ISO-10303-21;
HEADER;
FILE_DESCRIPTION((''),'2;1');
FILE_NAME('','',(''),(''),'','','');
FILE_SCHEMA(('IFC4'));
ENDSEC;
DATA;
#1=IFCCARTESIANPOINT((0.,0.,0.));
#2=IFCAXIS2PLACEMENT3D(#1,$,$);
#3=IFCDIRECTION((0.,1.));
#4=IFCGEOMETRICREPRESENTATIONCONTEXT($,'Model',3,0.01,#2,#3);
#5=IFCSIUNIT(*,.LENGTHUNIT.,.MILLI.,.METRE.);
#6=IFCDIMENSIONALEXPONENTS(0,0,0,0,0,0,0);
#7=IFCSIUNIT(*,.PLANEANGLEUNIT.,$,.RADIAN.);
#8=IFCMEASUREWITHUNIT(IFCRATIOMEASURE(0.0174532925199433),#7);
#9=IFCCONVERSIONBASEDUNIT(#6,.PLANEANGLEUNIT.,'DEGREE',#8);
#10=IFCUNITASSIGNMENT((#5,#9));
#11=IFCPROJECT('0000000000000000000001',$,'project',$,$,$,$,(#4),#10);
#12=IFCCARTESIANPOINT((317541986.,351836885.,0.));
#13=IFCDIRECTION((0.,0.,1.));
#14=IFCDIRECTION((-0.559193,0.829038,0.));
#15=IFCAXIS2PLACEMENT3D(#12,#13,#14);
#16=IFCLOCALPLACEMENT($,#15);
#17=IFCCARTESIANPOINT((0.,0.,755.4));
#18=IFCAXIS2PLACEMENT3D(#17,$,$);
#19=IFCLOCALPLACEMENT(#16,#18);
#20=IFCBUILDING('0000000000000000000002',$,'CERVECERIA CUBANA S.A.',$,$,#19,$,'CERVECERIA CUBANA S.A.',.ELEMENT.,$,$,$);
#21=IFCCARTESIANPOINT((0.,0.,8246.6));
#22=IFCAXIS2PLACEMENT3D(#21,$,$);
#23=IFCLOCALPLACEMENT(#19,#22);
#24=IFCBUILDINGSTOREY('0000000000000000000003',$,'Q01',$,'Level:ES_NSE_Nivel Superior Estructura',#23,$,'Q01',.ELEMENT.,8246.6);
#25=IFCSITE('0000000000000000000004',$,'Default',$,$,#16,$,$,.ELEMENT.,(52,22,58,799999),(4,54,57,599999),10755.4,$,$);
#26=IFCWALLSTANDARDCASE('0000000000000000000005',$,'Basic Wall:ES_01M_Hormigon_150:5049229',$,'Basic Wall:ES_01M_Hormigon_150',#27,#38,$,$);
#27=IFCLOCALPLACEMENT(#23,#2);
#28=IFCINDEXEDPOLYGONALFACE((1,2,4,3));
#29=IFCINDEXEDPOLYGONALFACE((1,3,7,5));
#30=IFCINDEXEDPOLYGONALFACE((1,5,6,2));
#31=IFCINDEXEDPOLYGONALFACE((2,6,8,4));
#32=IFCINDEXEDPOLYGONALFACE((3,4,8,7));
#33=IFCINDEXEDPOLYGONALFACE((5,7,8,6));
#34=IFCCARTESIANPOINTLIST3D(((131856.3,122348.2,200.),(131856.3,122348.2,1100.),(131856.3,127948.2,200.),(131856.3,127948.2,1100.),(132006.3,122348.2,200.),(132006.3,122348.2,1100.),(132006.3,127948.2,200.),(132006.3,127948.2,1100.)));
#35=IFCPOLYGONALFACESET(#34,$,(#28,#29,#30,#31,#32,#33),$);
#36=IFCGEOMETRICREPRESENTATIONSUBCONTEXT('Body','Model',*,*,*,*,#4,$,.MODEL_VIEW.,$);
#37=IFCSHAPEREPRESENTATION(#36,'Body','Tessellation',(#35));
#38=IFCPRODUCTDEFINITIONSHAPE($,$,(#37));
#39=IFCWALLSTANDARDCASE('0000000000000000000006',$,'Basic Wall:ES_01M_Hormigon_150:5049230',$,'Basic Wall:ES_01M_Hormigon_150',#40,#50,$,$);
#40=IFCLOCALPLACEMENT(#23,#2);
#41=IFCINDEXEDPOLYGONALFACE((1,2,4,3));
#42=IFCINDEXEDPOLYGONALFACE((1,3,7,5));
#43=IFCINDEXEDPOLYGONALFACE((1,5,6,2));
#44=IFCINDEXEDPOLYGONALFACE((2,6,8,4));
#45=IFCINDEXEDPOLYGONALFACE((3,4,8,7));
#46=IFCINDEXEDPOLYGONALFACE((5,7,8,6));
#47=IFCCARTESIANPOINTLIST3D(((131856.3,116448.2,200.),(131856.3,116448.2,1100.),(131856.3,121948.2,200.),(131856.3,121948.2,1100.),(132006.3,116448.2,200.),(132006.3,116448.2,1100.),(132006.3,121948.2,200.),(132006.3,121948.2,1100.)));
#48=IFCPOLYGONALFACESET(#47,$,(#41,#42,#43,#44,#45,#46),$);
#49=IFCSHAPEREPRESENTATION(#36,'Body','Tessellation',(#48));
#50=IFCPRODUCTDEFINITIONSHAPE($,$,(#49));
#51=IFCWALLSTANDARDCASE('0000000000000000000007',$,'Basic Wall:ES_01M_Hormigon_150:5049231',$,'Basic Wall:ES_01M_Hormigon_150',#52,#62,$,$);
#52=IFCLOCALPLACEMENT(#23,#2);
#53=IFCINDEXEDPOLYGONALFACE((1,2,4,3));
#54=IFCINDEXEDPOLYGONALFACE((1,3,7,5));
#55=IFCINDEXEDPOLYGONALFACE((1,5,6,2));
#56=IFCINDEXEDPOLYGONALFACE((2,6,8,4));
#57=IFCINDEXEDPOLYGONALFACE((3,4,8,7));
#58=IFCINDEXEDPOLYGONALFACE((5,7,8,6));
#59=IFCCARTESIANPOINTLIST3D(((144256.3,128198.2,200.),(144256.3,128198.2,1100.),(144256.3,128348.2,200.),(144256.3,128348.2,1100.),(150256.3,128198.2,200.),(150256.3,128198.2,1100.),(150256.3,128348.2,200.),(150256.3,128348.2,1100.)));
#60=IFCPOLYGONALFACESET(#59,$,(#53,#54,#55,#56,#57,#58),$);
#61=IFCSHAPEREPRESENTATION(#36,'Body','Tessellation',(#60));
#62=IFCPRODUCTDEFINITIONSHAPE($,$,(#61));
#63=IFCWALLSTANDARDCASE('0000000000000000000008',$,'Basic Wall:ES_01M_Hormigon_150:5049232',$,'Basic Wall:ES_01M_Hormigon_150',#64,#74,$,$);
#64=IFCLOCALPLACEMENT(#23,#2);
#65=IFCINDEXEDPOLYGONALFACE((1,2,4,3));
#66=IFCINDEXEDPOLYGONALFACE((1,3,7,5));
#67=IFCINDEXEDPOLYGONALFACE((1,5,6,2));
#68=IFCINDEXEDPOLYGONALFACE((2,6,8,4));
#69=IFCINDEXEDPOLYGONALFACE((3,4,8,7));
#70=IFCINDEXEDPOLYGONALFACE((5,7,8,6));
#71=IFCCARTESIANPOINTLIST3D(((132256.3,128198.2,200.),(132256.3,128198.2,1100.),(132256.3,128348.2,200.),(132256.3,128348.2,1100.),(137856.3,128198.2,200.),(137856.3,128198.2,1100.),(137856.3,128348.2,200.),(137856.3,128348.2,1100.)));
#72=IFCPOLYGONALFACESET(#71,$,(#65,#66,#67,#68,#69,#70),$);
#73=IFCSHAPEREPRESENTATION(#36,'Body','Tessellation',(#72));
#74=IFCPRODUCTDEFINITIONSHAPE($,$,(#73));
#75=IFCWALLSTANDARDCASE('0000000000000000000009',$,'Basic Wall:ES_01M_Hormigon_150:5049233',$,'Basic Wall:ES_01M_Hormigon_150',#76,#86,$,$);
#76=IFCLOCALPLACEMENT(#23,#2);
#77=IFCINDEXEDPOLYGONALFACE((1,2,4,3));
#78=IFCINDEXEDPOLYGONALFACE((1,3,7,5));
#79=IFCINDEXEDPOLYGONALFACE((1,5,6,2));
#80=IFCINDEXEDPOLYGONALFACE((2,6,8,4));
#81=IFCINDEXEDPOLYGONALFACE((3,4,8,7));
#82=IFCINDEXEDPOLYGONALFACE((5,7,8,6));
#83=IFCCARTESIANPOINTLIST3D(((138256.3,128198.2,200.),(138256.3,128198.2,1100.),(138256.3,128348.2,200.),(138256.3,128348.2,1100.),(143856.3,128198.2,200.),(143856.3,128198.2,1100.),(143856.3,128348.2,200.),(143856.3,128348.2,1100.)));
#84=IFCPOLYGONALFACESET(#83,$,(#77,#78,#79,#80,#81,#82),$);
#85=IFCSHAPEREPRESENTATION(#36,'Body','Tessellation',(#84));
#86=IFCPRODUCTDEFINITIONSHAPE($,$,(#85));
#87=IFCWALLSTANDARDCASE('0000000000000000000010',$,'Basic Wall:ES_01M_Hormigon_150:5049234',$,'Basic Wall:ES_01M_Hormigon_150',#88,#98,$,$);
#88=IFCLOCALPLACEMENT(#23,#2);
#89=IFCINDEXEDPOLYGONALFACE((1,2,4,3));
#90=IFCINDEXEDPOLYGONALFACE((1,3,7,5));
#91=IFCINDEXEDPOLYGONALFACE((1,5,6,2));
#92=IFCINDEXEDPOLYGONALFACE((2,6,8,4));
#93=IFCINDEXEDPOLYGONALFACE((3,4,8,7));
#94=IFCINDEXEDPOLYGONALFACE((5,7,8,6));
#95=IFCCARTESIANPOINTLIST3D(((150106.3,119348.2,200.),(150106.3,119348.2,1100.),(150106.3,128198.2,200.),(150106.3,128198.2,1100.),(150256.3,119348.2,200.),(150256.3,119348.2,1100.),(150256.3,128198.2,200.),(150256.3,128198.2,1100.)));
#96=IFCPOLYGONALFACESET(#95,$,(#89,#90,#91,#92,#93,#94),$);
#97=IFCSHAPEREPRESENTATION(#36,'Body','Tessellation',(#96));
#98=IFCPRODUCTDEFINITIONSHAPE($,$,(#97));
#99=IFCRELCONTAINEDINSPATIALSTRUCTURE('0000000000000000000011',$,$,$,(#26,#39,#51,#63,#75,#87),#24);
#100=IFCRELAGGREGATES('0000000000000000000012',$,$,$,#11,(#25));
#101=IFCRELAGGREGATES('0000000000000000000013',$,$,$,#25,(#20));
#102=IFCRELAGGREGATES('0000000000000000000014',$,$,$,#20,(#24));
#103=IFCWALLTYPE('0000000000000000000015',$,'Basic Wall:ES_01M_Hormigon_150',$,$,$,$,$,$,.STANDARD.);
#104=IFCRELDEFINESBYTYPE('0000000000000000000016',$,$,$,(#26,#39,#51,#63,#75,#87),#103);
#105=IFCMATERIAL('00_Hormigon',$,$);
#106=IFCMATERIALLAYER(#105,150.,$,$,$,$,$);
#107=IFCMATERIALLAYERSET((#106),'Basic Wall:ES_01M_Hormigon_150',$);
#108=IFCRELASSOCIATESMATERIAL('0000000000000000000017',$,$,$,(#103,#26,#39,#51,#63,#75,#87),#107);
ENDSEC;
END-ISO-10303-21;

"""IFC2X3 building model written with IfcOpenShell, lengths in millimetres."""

from ifc_helpers import new_model, entity, si_unit, converted_unit, direction, frame, frame_2d, origin, place, context, subcontext, project, spatial, rectangle, extrude, material, layer, layer_set, layer_usage, type_object, element, save


model = new_model("IFC2X3")

# Units and contexts
model_context = context("Model", 3, precision=0.01, world=origin(), true_north=direction((0.0, 1.0)))
body_context = subcontext(model_context, "Body", "Model", "MODEL_VIEW")
ifc_project = project(units=[si_unit("LENGTHUNIT", "METRE", prefix="MILLI"), converted_unit("PLANEANGLEUNIT", "DEGREE", entity("IfcRatioMeasure", 0.0174532925199433), si_unit("PLANEANGLEUNIT", "RADIAN"), dimensions=[0, 0, 0, 0, 0, 0, 0])], contexts=[model_context])

# Site, building, storey
site_placement = place(None, frame((317541986.0, 351836885.0, 0.0), z_axis=(0.0, 0.0, 1.0), x_axis=(-0.559193, 0.829038, 0.0)))
site = spatial("IfcSite", under=ifc_project, at=site_placement, Name="Default", CompositionType="ELEMENT", RefLatitude=(52, 22, 58, 799999), RefLongitude=(4, 54, 57, 599999), RefElevation=10755.4)
building_placement = place(site_placement, frame((0.0, 0.0, 755.4)))
building = spatial("IfcBuilding", under=site, at=building_placement, Name="CERVECERIA CUBANA S.A.", LongName="CERVECERIA CUBANA S.A.", CompositionType="ELEMENT")
storey_placement = place(building_placement, frame((0.0, 0.0, 8246.6)))
storey = spatial("IfcBuildingStorey", under=building, at=storey_placement, Name="Q01", ObjectType="Level:ES_NSE_Nivel Superior Estructura", LongName="Q01", CompositionType="ELEMENT", Elevation=8246.6)

# Shared definitions
ifc_material_1 = material(Name="00_Hormigon")

# Walls
ifc_layer_1 = layer(ifc_material_1, 150.0)
ifc_layer_set_1 = layer_set([ifc_layer_1], Name="Basic Wall:ES_01M_Hormigon_150")
wall_type = type_object("IfcWallType", Name="Basic Wall:ES_01M_Hormigon_150", PredefinedType="STANDARD", material=ifc_layer_set_1)
ifc_layer_usage_1 = layer_usage(ifc_layer_set_1, "AXIS2", "NEGATIVE", 75.0)
wall_1_placement = place(storey_placement, frame((131931.3, 127948.2, 200.0), z_axis=(0.0, 0.0, 1.0), x_axis=(0.0, -1.0, 0.0)))
element("IfcWallStandardCase", 1, at=wall_1_placement, inside=storey, type_object=wall_type, material=ifc_layer_usage_1, Name="Basic Wall:ES_01M_Hormigon_150:5049229", ObjectType="Basic Wall:ES_01M_Hormigon_150", context=body_context, shape_type="SweptSolid", body=[
    extrude(rectangle(XDim=5600.0, YDim=150.0, at=frame_2d((2800.0, 0.0), x_axis=(-1.0, 0.0))), origin(), (0.0, 0.0, 1.0), 900.0),
])
ifc_layer_usage_2 = layer_usage(ifc_layer_set_1, "AXIS2", "NEGATIVE", 75.0)
wall_2_placement = place(storey_placement, frame((131931.3, 121948.2, 200.0), z_axis=(0.0, 0.0, 1.0), x_axis=(0.0, -1.0, 0.0)))
element("IfcWallStandardCase", 2, at=wall_2_placement, inside=storey, type_object=wall_type, material=ifc_layer_usage_2, Name="Basic Wall:ES_01M_Hormigon_150:5049230", ObjectType="Basic Wall:ES_01M_Hormigon_150", context=body_context, shape_type="SweptSolid", body=[
    extrude(rectangle(XDim=5500.0, YDim=150.0, at=frame_2d((2750.0, 0.0), x_axis=(-1.0, 0.0))), origin(), (0.0, 0.0, 1.0), 900.0),
])
ifc_layer_usage_3 = layer_usage(ifc_layer_set_1, "AXIS2", "NEGATIVE", 75.0)
wall_3_placement = place(storey_placement, frame((150256.3, 128273.2, 200.0), z_axis=(0.0, 0.0, 1.0), x_axis=(-1.0, 0.0, 0.0)))
element("IfcWallStandardCase", 3, at=wall_3_placement, inside=storey, type_object=wall_type, material=ifc_layer_usage_3, Name="Basic Wall:ES_01M_Hormigon_150:5049231", ObjectType="Basic Wall:ES_01M_Hormigon_150", context=body_context, shape_type="SweptSolid", body=[
    extrude(rectangle(XDim=6000.0, YDim=150.0, at=frame_2d((3000.0, 0.0), x_axis=(-1.0, 0.0))), origin(), (0.0, 0.0, 1.0), 900.0),
])
ifc_layer_usage_4 = layer_usage(ifc_layer_set_1, "AXIS2", "NEGATIVE", 75.0)
wall_4_placement = place(storey_placement, frame((137856.3, 128273.2, 200.0), z_axis=(0.0, 0.0, 1.0), x_axis=(-1.0, 0.0, 0.0)))
element("IfcWallStandardCase", 4, at=wall_4_placement, inside=storey, type_object=wall_type, material=ifc_layer_usage_4, Name="Basic Wall:ES_01M_Hormigon_150:5049232", ObjectType="Basic Wall:ES_01M_Hormigon_150", context=body_context, shape_type="SweptSolid", body=[
    extrude(rectangle(XDim=5600.0, YDim=150.0, at=frame_2d((2800.0, 0.0), x_axis=(-1.0, 0.0))), origin(), (0.0, 0.0, 1.0), 900.0),
])
ifc_layer_usage_5 = layer_usage(ifc_layer_set_1, "AXIS2", "NEGATIVE", 75.0)
wall_5_placement = place(storey_placement, frame((143856.3, 128273.2, 200.0), z_axis=(0.0, 0.0, 1.0), x_axis=(-1.0, 0.0, 0.0)))
element("IfcWallStandardCase", 5, at=wall_5_placement, inside=storey, type_object=wall_type, material=ifc_layer_usage_5, Name="Basic Wall:ES_01M_Hormigon_150:5049233", ObjectType="Basic Wall:ES_01M_Hormigon_150", context=body_context, shape_type="SweptSolid", body=[
    extrude(rectangle(XDim=5600.0, YDim=150.0, at=frame_2d((2800.0, 0.0), x_axis=(-1.0, 0.0))), origin(), (0.0, 0.0, 1.0), 900.0),
])
ifc_layer_usage_6 = layer_usage(ifc_layer_set_1, "AXIS2", "NEGATIVE", 75.0)
wall_6_placement = place(storey_placement, frame((150181.3, 128198.2, 200.0), z_axis=(0.0, 0.0, 1.0), x_axis=(0.0, -1.0, 0.0)))
element("IfcWallStandardCase", 6, at=wall_6_placement, inside=storey, type_object=wall_type, material=ifc_layer_usage_6, Name="Basic Wall:ES_01M_Hormigon_150:5049234", ObjectType="Basic Wall:ES_01M_Hormigon_150", context=body_context, shape_type="SweptSolid", body=[
    extrude(rectangle(XDim=8850.0, YDim=150.0, at=frame_2d((4425.0, 0.0), x_axis=(-1.0, 0.0))), origin(), (0.0, 0.0, 1.0), 900.0),
])

save(model, "model.ifc")
